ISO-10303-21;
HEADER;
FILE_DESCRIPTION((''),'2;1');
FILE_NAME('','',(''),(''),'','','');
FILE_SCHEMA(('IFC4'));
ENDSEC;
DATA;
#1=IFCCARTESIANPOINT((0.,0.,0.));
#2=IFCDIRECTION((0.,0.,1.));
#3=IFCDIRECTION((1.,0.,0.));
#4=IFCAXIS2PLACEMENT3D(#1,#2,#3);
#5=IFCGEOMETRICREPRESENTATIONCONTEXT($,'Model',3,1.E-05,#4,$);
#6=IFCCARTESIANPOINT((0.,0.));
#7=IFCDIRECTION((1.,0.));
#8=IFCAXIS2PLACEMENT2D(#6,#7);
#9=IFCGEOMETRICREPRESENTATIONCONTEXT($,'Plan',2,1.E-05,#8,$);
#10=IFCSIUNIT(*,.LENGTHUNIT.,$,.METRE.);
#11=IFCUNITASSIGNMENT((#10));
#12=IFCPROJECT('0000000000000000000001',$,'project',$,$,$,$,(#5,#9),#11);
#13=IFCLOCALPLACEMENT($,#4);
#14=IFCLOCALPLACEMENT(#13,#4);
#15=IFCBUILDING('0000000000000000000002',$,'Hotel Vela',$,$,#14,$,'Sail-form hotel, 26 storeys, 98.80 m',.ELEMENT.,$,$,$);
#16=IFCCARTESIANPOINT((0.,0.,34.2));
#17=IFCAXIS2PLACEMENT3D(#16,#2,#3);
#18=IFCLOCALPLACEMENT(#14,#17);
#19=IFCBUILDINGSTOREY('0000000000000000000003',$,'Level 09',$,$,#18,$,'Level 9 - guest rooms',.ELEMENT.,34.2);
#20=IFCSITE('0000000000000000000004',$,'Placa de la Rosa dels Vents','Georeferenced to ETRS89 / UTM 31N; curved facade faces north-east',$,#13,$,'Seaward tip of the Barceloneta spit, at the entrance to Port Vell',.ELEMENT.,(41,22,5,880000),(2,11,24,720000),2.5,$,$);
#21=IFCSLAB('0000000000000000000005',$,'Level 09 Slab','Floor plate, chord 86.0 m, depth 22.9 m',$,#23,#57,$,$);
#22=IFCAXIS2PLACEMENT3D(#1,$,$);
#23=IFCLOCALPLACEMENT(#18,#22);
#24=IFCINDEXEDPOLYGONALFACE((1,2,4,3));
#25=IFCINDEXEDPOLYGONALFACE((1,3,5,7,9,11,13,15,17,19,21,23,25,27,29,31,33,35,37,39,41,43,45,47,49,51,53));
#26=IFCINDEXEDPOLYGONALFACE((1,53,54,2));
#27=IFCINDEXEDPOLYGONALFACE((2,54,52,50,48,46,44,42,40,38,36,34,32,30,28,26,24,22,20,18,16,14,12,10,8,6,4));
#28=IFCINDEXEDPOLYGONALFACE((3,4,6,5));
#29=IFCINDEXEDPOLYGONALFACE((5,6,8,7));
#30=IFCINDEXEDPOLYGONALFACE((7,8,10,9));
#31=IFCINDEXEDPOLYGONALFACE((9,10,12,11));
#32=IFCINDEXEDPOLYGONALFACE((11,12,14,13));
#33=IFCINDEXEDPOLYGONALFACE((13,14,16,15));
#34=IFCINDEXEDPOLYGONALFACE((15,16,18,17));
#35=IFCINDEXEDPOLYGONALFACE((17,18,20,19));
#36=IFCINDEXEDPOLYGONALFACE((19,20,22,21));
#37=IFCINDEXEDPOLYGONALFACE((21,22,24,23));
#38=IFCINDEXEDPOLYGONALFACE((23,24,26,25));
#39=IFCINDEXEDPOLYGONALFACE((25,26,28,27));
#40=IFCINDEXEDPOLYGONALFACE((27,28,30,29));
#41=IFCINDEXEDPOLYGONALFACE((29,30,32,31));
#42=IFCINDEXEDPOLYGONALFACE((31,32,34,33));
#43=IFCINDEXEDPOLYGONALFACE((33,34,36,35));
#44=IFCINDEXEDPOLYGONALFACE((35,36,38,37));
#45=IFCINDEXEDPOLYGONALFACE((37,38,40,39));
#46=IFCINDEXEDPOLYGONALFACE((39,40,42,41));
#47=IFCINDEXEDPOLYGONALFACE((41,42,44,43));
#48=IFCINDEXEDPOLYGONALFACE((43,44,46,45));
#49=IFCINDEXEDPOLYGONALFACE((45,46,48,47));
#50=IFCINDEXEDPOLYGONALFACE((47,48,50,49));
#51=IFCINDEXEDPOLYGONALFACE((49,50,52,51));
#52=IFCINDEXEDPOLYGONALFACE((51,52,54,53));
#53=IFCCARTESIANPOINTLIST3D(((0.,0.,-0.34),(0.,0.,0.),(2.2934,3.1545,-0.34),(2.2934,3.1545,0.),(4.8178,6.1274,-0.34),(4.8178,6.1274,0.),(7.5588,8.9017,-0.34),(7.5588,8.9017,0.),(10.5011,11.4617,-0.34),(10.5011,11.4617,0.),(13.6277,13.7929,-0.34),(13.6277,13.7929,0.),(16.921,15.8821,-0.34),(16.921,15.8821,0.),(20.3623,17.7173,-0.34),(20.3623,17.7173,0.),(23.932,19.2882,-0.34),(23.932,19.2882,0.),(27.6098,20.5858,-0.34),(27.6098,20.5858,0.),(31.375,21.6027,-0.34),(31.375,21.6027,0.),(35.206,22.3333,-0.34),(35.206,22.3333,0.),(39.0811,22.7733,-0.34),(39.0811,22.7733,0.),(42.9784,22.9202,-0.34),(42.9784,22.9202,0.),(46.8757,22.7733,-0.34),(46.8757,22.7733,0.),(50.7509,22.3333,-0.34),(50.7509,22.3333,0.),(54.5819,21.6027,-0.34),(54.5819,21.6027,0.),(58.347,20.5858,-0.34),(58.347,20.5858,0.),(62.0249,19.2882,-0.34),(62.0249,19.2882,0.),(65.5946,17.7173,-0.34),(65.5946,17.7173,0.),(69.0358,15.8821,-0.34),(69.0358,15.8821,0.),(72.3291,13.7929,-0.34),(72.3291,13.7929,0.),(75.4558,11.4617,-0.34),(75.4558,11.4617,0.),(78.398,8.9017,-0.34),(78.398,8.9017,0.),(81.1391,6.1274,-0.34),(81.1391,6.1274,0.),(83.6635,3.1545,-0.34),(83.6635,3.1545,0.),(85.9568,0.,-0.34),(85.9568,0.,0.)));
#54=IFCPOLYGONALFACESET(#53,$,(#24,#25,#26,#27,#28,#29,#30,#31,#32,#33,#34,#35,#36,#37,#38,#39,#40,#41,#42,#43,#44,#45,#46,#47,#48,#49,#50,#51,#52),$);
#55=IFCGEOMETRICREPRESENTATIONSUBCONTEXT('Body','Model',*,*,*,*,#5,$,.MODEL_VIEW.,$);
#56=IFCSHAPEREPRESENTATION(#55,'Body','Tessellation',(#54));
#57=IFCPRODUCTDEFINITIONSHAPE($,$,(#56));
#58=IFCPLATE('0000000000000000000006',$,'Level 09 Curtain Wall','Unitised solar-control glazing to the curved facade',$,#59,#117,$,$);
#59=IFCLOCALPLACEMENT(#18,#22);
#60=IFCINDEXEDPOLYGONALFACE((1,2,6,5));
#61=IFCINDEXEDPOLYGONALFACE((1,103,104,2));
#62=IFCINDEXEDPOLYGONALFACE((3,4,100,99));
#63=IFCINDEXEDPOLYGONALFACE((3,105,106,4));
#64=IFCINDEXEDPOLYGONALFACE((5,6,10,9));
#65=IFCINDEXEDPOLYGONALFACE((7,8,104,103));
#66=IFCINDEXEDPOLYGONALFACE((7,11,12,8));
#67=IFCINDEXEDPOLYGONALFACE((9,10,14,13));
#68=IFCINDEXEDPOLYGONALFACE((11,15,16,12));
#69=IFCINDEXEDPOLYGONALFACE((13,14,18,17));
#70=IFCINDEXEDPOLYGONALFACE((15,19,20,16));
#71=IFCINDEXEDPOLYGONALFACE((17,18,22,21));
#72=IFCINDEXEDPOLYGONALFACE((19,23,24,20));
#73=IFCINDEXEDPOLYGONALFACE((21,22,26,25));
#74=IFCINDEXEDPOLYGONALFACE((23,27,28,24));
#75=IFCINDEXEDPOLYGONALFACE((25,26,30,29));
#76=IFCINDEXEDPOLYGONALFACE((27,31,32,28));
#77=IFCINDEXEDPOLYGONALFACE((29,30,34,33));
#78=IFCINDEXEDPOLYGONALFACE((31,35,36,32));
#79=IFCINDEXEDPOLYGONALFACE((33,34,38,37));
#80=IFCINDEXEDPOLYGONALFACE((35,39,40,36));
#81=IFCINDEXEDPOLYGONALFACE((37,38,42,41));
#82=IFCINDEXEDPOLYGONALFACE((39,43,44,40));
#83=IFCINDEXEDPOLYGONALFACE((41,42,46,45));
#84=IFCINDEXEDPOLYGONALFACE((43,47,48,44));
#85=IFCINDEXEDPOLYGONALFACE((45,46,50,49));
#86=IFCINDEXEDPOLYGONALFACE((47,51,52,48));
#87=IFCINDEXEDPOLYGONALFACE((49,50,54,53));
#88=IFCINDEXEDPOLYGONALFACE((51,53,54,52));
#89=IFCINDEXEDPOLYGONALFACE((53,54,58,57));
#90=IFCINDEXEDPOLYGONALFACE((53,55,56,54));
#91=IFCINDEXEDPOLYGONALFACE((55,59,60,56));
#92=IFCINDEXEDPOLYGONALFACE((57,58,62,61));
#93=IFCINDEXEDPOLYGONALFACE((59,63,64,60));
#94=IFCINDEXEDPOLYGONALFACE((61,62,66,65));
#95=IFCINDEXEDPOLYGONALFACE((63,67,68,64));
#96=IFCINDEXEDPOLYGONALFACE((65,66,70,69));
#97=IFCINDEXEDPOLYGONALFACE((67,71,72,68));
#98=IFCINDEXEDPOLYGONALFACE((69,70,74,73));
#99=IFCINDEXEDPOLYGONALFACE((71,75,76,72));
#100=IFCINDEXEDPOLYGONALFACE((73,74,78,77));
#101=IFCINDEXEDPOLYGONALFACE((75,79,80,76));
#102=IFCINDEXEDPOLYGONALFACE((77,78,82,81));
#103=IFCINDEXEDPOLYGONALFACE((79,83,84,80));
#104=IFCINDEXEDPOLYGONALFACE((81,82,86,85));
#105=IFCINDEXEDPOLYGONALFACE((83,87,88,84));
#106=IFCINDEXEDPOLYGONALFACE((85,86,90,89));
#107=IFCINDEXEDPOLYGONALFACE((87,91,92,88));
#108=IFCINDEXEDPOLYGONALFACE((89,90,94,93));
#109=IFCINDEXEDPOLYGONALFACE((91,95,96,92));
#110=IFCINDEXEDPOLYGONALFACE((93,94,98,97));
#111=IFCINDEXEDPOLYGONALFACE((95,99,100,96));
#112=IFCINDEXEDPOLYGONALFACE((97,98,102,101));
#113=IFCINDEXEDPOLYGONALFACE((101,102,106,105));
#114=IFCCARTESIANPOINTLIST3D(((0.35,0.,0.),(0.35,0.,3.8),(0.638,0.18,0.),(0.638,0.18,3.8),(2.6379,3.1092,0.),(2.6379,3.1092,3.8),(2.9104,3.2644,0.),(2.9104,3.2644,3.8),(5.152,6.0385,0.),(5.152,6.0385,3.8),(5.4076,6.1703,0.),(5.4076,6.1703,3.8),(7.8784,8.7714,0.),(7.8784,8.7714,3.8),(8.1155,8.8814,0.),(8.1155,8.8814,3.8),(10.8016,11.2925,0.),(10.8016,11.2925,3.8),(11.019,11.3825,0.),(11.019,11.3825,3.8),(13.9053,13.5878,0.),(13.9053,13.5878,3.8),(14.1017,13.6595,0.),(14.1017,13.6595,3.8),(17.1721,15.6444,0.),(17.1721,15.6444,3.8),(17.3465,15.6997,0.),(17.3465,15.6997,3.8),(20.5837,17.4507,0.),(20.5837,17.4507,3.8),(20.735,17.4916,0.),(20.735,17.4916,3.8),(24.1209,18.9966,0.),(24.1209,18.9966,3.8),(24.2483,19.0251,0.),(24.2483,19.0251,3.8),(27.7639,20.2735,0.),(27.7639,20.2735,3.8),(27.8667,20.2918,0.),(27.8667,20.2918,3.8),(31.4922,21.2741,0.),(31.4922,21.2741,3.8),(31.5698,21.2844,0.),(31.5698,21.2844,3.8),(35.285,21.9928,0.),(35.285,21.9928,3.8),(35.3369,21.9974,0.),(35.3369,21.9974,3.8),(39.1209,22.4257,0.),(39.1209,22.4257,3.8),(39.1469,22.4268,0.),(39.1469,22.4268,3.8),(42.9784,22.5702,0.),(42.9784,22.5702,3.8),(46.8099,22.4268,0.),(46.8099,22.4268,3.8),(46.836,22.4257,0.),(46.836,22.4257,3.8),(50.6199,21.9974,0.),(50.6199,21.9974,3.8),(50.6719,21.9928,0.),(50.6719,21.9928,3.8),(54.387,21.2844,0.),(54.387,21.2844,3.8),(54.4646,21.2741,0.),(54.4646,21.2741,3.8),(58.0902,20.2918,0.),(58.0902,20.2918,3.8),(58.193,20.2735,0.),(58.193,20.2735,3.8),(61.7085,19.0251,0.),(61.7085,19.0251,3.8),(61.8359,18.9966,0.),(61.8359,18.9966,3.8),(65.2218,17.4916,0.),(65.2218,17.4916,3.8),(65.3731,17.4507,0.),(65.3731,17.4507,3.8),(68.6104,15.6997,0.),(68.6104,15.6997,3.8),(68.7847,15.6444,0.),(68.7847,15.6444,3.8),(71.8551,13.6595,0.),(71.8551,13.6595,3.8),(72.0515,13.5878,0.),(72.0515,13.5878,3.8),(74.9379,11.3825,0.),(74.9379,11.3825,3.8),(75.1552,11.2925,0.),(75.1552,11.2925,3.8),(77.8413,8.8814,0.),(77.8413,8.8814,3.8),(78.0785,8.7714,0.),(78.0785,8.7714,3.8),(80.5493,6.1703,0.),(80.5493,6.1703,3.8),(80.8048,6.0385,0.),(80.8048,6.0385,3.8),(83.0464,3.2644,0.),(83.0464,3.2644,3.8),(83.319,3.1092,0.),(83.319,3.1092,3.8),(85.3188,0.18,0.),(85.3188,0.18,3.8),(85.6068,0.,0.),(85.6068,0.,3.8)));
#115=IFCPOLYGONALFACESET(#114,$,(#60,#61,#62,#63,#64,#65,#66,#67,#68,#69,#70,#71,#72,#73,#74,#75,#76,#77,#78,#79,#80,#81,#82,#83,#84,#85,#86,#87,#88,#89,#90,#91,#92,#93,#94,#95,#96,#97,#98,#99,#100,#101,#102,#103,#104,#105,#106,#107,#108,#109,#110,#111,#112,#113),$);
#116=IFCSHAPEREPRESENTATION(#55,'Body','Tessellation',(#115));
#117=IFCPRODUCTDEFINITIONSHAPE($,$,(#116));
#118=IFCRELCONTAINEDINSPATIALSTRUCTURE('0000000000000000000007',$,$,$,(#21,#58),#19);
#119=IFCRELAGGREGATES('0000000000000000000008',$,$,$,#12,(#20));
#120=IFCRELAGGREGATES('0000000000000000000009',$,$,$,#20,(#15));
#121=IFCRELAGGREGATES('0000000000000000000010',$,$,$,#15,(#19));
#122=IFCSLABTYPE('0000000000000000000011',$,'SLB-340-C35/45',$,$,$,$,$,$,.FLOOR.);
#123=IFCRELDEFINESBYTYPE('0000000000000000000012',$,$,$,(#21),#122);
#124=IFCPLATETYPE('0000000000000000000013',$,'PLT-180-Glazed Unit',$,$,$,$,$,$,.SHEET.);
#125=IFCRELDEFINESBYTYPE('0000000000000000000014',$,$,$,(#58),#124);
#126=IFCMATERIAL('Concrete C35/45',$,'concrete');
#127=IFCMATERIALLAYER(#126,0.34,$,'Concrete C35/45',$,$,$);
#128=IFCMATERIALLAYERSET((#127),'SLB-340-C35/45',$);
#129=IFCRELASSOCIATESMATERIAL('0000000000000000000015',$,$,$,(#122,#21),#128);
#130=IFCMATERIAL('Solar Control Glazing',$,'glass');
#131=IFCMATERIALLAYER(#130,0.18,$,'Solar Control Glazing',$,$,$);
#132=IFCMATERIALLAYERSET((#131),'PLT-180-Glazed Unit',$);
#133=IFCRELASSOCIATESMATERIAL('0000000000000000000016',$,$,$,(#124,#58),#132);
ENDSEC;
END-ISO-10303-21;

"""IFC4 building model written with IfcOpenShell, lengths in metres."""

from ifc_helpers import new_model, si_unit, frame, origin_with_axes, origin_2d_with_axis, place, context, subcontext, project, spatial, line, indexed_curve, outline, extrude, material, layer, layer_set, layer_usage, type_object, element, save


model = new_model("IFC4")

# Units and contexts
model_context = context("Model", 3, precision=1e-05, world=origin_with_axes())
plan_context = context("Plan", 2, precision=1e-05, world=origin_2d_with_axis())
body_context = subcontext(model_context, "Body", "Model", "MODEL_VIEW")
ifc_project = project(units=[si_unit("LENGTHUNIT", "METRE")], contexts=[model_context, plan_context])

# Site, building, storey
site_placement = place(None, origin_with_axes())
site = spatial("IfcSite", under=ifc_project, at=site_placement, Name="Placa de la Rosa dels Vents", Description="Georeferenced to ETRS89 / UTM 31N; curved facade faces north-east", LongName="Seaward tip of the Barceloneta spit, at the entrance to Port Vell", CompositionType="ELEMENT", RefLatitude=(41, 22, 5, 880000), RefLongitude=(2, 11, 24, 720000), RefElevation=2.5)
building_placement = place(site_placement, origin_with_axes())
building = spatial("IfcBuilding", under=site, at=building_placement, Name="Hotel Vela", LongName="Sail-form hotel, 26 storeys, 98.80 m", CompositionType="ELEMENT")
storey_placement = place(building_placement, frame((0.0, 0.0, 34.2), z_axis=(0.0, 0.0, 1.0), x_axis=(1.0, 0.0, 0.0)))
storey = spatial("IfcBuildingStorey", under=building, at=storey_placement, Name="Level 09", LongName="Level 9 - guest rooms", CompositionType="ELEMENT", Elevation=34.2)

# Slab
ifc_material_1 = material(Name="Concrete C35/45", Category="concrete")
ifc_layer_1 = layer(ifc_material_1, 0.34, Name="Concrete C35/45")
ifc_layer_set_1 = layer_set([ifc_layer_1], Name="SLB-340-C35/45")
ifc_layer_usage_1 = layer_usage(ifc_layer_set_1, "AXIS3", "POSITIVE", 0.0)
slab_type = type_object("IfcSlabType", Name="SLB-340-C35/45", PredefinedType="FLOOR", material=ifc_layer_set_1)
slab_placement = place(storey_placement, frame((0.0, 0.0, -0.34), z_axis=(0.0, 0.0, 1.0), x_axis=(1.0, 0.0, 0.0)))
element("IfcSlab", 1, at=slab_placement, inside=storey, type_object=slab_type, material=ifc_layer_usage_1, Name="Level 09 Slab", Description="Floor plate, chord 86.0 m, depth 22.9 m", context=body_context, shape_type="SweptSolid", body=[
    extrude(outline(indexed_curve([(0.0, 0.0), (85.9568, 0.0), (83.6635, 3.1545), (81.1391, 6.1274), (78.398, 8.9017), (75.4558, 11.4617), (72.3291, 13.7929), (69.0358, 15.8821), (65.5946, 17.7173), (62.0249, 19.2882), (58.347, 20.5858), (54.5819, 21.6027), (50.7509, 22.3333), (46.8757, 22.7733), (42.9784, 22.9202), (39.0811, 22.7733), (35.206, 22.3333), (31.375, 21.6027), (27.6098, 20.5858), (23.932, 19.2882), (20.3623, 17.7173), (16.921, 15.8821), (13.6277, 13.7929), (10.5011, 11.4617), (7.5588, 8.9017), (4.8178, 6.1274), (2.2934, 3.1545)], segments=[line(1, 2, 3, 4, 5, 6, 7, 8, 9, 10, 11, 12, 13, 14, 15, 16, 17, 18, 19, 20, 21, 22, 23, 24, 25, 26, 27, 1)])), origin_with_axes(), (0.0, 0.0, 1.0), 0.34),
])

# Plate
ifc_material_2 = material(Name="Solar Control Glazing", Category="glass")
ifc_layer_2 = layer(ifc_material_2, 0.18, Name="Solar Control Glazing")
ifc_layer_set_2 = layer_set([ifc_layer_2], Name="PLT-180-Glazed Unit")
ifc_layer_usage_2 = layer_usage(ifc_layer_set_2, "AXIS2", "POSITIVE", 0.0)
plate_type_1 = type_object("IfcPlateType", Name="PLT-180-Glazed Unit", PredefinedType="SHEET", material=ifc_layer_set_2)
plate_1_placement = place(storey_placement, frame((0.35, 0.0, 0.0), z_axis=(0.0, 0.0, 1.0), x_axis=(1.0, 0.0, 0.0)))
element("IfcPlate", 2, at=plate_1_placement, inside=storey, type_object=plate_type_1, material=ifc_layer_usage_2, Name="Level 09 Curtain Wall", Description="Unitised solar-control glazing to the curved facade", context=body_context, shape_type="SweptSolid", body=[
    extrude(outline(indexed_curve([(85.2568, 0.0), (82.969, 3.1092), (80.4548, 6.0385), (77.7285, 8.7714), (74.8052, 11.2925), (71.7015, 13.5878), (68.4347, 15.6444), (65.0231, 17.4507), (61.4859, 18.9966), (57.843, 20.2735), (54.1146, 21.2741), (50.3219, 21.9928), (46.486, 22.4257), (42.6284, 22.5702), (38.7709, 22.4257), (34.935, 21.9928), (31.1422, 21.2741), (27.4139, 20.2735), (23.7709, 18.9966), (20.2337, 17.4507), (16.8221, 15.6444), (13.5553, 13.5878), (10.4516, 11.2925), (7.5284, 8.7714), (4.802, 6.0385), (2.2879, 3.1092), (0.0, 0.0), (84.9688, 0.18), (2.5604, 3.2644), (5.0576, 6.1703), (7.7655, 8.8814), (10.669, 11.3825), (13.7517, 13.6595), (16.9965, 15.6997), (20.385, 17.4916), (23.8983, 19.0251), (27.5167, 20.2918), (31.2198, 21.2844), (34.9869, 21.9974), (38.7969, 22.4268), (42.6284, 22.5702), (46.4599, 22.4268), (50.2699, 21.9974), (54.037, 21.2844), (57.7402, 20.2918), (61.3585, 19.0251), (64.8718, 17.4916), (68.2604, 15.6997), (71.5051, 13.6595), (74.5879, 11.3825), (77.4913, 8.8814), (80.1993, 6.1703), (82.6964, 3.2644), (0.288, 0.18)], segments=[line(1, 2, 3, 4, 5, 6, 7, 8, 9, 10, 11, 12, 13, 14, 15, 16, 17, 18, 19, 20, 21, 22, 23, 24, 25, 26, 27, 28, 29, 30, 31, 32, 33, 34, 35, 36, 37, 38, 39, 40, 41, 42, 43, 44, 45, 46, 47, 48, 49, 50, 51, 52, 53, 54, 1)])), origin_with_axes(), (0.0, 0.0, 1.0), 3.8),
])

save(model, "model.ifc")
